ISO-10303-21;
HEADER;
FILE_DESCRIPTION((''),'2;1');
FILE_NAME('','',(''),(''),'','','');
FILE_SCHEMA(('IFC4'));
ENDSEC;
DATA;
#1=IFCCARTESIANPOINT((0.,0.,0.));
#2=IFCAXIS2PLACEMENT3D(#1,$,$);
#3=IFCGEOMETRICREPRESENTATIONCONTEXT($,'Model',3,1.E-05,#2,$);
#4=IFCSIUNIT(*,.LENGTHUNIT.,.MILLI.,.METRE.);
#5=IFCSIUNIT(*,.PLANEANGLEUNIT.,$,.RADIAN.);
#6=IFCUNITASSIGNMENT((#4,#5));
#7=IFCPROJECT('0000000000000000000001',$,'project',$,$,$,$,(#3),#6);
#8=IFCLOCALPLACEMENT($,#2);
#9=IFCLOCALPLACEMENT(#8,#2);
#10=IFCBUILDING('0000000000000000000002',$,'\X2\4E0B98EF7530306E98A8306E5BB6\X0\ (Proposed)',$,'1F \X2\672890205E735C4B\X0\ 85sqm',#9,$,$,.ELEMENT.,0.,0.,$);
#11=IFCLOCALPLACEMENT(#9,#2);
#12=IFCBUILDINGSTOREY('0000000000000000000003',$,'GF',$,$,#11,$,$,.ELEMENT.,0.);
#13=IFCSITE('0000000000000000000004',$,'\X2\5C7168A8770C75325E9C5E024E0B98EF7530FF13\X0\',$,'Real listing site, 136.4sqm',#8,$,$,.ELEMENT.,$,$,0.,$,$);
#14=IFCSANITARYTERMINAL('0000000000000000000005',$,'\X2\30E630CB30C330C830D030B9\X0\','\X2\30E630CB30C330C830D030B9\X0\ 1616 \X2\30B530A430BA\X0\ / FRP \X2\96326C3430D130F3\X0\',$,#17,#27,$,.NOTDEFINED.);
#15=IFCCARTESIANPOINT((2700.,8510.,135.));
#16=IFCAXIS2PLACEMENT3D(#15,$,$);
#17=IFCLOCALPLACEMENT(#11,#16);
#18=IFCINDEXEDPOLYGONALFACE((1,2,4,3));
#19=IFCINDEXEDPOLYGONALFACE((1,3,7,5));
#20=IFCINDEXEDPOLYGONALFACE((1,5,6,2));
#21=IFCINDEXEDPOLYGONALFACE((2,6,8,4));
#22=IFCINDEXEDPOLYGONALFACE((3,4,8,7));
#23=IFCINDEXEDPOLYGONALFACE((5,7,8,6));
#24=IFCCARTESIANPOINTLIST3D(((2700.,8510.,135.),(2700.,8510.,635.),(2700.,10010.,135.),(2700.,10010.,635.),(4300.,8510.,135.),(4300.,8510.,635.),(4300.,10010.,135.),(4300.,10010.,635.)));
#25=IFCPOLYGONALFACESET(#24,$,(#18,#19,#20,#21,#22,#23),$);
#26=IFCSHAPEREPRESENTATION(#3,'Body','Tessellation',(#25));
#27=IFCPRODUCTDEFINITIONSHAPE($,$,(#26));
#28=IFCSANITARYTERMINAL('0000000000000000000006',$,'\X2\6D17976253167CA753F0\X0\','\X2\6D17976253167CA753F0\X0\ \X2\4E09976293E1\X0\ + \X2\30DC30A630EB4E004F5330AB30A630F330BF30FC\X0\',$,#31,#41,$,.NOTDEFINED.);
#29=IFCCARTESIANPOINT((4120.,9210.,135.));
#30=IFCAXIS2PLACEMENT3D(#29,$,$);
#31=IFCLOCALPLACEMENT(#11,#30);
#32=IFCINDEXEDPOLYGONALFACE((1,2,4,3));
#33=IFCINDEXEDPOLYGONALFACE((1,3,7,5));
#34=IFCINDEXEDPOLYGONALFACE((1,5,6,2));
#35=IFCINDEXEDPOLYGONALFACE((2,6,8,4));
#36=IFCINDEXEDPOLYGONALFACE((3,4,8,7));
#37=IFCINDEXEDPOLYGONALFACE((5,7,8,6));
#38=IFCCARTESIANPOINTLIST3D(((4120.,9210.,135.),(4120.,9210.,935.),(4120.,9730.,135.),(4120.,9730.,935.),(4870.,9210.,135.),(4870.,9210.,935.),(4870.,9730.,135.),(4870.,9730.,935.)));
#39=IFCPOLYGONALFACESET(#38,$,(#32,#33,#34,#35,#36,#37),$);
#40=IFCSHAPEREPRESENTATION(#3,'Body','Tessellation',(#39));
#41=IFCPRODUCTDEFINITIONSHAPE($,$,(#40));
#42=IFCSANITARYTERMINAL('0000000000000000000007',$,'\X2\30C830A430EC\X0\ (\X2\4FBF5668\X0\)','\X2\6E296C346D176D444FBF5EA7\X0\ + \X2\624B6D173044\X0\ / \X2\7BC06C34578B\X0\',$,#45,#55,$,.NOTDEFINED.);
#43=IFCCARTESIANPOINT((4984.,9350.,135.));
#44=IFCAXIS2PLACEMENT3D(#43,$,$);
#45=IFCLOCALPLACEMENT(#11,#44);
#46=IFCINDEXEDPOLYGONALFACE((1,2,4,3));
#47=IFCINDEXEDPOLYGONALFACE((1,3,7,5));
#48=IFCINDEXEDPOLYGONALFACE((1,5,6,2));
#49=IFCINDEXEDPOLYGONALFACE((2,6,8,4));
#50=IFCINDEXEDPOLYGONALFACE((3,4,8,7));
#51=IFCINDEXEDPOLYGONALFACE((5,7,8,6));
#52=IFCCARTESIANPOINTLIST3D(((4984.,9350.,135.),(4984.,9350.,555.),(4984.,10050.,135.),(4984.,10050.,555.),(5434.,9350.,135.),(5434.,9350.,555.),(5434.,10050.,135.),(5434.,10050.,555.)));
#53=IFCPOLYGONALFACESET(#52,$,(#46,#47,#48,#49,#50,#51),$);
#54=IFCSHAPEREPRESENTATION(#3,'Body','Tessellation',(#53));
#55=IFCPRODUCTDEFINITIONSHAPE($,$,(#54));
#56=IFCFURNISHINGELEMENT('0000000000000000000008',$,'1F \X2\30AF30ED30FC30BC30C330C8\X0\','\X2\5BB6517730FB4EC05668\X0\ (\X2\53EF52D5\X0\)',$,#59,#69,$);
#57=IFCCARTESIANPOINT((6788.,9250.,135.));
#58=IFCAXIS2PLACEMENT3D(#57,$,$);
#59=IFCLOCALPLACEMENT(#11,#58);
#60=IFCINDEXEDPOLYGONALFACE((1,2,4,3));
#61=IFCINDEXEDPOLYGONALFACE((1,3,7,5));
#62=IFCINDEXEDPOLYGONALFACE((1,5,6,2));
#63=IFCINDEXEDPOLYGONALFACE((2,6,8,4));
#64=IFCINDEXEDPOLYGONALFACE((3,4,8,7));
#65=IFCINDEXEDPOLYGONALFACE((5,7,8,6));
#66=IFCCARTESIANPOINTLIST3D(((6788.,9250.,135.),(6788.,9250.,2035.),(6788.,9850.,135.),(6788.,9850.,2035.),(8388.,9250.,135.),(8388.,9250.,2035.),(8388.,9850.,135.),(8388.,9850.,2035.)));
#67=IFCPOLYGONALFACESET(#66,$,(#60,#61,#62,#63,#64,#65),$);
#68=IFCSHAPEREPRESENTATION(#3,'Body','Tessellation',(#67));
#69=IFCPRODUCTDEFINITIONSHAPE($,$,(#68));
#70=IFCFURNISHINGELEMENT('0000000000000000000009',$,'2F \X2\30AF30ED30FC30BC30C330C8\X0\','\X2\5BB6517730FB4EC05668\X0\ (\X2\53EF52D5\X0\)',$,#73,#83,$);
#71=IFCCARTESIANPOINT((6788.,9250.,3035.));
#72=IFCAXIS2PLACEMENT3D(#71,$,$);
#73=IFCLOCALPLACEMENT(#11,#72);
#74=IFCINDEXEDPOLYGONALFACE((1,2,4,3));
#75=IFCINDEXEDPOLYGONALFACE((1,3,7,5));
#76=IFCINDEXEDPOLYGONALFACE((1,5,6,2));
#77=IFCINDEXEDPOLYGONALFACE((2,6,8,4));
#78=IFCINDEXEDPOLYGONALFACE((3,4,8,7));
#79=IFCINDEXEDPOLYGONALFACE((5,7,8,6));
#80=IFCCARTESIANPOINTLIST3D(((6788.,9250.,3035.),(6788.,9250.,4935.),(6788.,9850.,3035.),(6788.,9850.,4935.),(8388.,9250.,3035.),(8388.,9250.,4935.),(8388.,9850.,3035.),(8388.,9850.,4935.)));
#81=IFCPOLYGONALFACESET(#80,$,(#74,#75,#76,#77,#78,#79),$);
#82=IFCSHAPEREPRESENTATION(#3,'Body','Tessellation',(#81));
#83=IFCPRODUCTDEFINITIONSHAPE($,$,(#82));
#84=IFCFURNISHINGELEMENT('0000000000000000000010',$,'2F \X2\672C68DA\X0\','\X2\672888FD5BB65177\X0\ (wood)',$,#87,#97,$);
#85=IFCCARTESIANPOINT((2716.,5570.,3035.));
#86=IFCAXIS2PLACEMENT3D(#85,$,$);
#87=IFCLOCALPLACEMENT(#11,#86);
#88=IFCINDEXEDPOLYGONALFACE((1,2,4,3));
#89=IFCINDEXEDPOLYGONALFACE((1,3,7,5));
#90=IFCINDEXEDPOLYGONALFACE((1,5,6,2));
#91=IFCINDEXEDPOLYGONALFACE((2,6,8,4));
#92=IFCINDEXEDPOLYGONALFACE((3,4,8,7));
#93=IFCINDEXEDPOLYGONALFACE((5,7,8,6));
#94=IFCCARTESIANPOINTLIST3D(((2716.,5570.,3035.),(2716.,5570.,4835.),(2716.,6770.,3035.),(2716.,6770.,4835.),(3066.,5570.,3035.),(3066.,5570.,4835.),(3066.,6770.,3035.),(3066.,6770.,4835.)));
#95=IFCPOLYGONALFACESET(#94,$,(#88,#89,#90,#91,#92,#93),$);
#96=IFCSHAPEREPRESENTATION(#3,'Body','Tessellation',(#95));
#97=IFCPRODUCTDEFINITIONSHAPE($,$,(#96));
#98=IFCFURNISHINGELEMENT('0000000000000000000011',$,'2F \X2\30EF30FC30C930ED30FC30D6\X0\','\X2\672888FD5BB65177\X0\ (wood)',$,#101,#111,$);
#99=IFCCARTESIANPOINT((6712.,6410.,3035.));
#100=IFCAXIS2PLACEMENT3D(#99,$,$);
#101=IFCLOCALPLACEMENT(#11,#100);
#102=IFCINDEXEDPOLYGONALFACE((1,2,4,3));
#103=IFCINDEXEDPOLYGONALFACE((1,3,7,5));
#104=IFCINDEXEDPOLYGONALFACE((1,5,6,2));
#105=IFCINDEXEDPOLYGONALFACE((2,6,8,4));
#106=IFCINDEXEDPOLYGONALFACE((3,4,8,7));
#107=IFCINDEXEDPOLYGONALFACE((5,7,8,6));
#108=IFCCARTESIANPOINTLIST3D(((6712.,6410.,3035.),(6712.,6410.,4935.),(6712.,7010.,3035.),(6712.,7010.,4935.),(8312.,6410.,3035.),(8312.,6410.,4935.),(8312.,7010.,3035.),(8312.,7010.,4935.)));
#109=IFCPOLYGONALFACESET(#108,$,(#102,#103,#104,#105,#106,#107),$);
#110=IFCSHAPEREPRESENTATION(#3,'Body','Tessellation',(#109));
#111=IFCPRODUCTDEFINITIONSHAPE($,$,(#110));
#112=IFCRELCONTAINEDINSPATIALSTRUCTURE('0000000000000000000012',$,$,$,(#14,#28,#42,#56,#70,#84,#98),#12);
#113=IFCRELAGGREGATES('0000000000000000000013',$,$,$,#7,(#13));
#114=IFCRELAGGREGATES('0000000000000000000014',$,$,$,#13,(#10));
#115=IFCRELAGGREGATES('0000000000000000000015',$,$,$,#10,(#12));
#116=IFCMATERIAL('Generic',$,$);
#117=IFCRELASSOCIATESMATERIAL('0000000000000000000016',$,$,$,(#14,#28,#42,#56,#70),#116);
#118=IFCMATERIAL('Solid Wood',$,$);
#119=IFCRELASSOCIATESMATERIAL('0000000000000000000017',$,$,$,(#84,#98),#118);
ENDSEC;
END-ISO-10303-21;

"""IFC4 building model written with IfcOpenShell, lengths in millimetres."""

from ifc_helpers import new_model, si_unit, frame, frame_2d, origin, place, context, project, spatial, rectangle, extrude, material, element, save


model = new_model("IFC4")

# Units and contexts
model_context = context("Model", 3, precision=1e-05, world=origin())
ifc_project = project(units=[si_unit("LENGTHUNIT", "METRE", prefix="MILLI"), si_unit("PLANEANGLEUNIT", "RADIAN")], contexts=[model_context])

# Site, building, storey
site_placement = place(None, origin())
site = spatial("IfcSite", under=ifc_project, at=site_placement, Name="山梨県甲府市下飯田３", ObjectType="Real listing site, 136.4sqm", CompositionType="ELEMENT", RefElevation=0.0)
building_placement = place(site_placement, origin())
building = spatial("IfcBuilding", under=site, at=building_placement, Name="下飯田の風の家 (Proposed)", ObjectType="1F 木造平屋 85sqm", CompositionType="ELEMENT", ElevationOfRefHeight=0.0, ElevationOfTerrain=0.0)
storey_placement = place(building_placement, origin())
storey = spatial("IfcBuildingStorey", under=building, at=storey_placement, Name="GF", CompositionType="ELEMENT", Elevation=0.0)

# Shared definitions
ifc_material_1 = material(Name="Solid Wood")

# Shared definitions
ifc_material_2 = material(Name="Generic")

# Sanitary terminals
sanitary_terminal_1_placement = place(storey_placement, frame((2700.0, 8510.0, 135.0)))
element("IfcSanitaryTerminal", 1, at=sanitary_terminal_1_placement, inside=storey, material=ifc_material_2, Name="ユニットバス", Description="ユニットバス 1616 サイズ / FRP 防水パン", PredefinedType="NOTDEFINED", context=model_context, shape_type="SweptSolid", body=[
    extrude(rectangle(XDim=1600.0, YDim=1500.0, at=frame_2d((800.0, 750.0))), frame((2700.0, 8510.0, 135.0)), (0.0, 0.0, 1.0), 500.0),
])
sanitary_terminal_2_placement = place(storey_placement, frame((4120.0, 9210.0, 135.0)))
element("IfcSanitaryTerminal", 2, at=sanitary_terminal_2_placement, inside=storey, material=ifc_material_2, Name="洗面化粧台", Description="洗面化粧台 三面鏡 + ボウル一体カウンター", PredefinedType="NOTDEFINED", context=model_context, shape_type="SweptSolid", body=[
    extrude(rectangle(XDim=750.0, YDim=520.0, at=frame_2d((375.0, 260.0))), frame((4120.0, 9210.0, 135.0)), (0.0, 0.0, 1.0), 800.0),
])
sanitary_terminal_3_placement = place(storey_placement, frame((4984.0, 9350.0, 135.0)))
element("IfcSanitaryTerminal", 3, at=sanitary_terminal_3_placement, inside=storey, material=ifc_material_2, Name="トイレ (便器)", Description="温水洗浄便座 + 手洗い / 節水型", PredefinedType="NOTDEFINED", context=model_context, shape_type="SweptSolid", body=[
    extrude(rectangle(XDim=450.0, YDim=700.0, at=frame_2d((225.0, 350.0))), frame((4984.0, 9350.0, 135.0)), (0.0, 0.0, 1.0), 420.0),
])

# Furnishing elements
furnishing_1_placement = place(storey_placement, frame((6788.0, 9250.0, 135.0)))
element("IfcFurnishingElement", 4, at=furnishing_1_placement, inside=storey, material=ifc_material_2, Name="1F クローゼット", Description="家具・什器 (可動)", context=model_context, shape_type="SweptSolid", body=[
    extrude(rectangle(XDim=1600.0, YDim=600.0, at=frame_2d((800.0, 300.0))), frame((6788.0, 9250.0, 135.0)), (0.0, 0.0, 1.0), 1900.0),
])
furnishing_2_placement = place(storey_placement, frame((6788.0, 9250.0, 3035.0)))
element("IfcFurnishingElement", 5, at=furnishing_2_placement, inside=storey, material=ifc_material_2, Name="2F クローゼット", Description="家具・什器 (可動)", context=model_context, shape_type="SweptSolid", body=[
    extrude(rectangle(XDim=1600.0, YDim=600.0, at=frame_2d((800.0, 300.0))), frame((6788.0, 9250.0, 3035.0)), (0.0, 0.0, 1.0), 1900.0),
])
furnishing_3_placement = place(storey_placement, frame((2716.0, 5570.0, 3035.0)))
element("IfcFurnishingElement", 6, at=furnishing_3_placement, inside=storey, material=ifc_material_1, Name="2F 本棚", Description="木製家具 (wood)", context=model_context, shape_type="SweptSolid", body=[
    extrude(rectangle(XDim=350.0, YDim=1200.0, at=frame_2d((175.0, 600.0))), frame((2716.0, 5570.0, 3035.0)), (0.0, 0.0, 1.0), 1800.0),
])
furnishing_4_placement = place(storey_placement, frame((6712.0, 6410.0, 3035.0)))
element("IfcFurnishingElement", 7, at=furnishing_4_placement, inside=storey, material=ifc_material_1, Name="2F ワードローブ", Description="木製家具 (wood)", context=model_context, shape_type="SweptSolid", body=[
    extrude(rectangle(XDim=1600.0, YDim=600.0, at=frame_2d((800.0, 300.0))), frame((6712.0, 6410.0, 3035.0)), (0.0, 0.0, 1.0), 1900.0),
])

save(model, "model.ifc")
